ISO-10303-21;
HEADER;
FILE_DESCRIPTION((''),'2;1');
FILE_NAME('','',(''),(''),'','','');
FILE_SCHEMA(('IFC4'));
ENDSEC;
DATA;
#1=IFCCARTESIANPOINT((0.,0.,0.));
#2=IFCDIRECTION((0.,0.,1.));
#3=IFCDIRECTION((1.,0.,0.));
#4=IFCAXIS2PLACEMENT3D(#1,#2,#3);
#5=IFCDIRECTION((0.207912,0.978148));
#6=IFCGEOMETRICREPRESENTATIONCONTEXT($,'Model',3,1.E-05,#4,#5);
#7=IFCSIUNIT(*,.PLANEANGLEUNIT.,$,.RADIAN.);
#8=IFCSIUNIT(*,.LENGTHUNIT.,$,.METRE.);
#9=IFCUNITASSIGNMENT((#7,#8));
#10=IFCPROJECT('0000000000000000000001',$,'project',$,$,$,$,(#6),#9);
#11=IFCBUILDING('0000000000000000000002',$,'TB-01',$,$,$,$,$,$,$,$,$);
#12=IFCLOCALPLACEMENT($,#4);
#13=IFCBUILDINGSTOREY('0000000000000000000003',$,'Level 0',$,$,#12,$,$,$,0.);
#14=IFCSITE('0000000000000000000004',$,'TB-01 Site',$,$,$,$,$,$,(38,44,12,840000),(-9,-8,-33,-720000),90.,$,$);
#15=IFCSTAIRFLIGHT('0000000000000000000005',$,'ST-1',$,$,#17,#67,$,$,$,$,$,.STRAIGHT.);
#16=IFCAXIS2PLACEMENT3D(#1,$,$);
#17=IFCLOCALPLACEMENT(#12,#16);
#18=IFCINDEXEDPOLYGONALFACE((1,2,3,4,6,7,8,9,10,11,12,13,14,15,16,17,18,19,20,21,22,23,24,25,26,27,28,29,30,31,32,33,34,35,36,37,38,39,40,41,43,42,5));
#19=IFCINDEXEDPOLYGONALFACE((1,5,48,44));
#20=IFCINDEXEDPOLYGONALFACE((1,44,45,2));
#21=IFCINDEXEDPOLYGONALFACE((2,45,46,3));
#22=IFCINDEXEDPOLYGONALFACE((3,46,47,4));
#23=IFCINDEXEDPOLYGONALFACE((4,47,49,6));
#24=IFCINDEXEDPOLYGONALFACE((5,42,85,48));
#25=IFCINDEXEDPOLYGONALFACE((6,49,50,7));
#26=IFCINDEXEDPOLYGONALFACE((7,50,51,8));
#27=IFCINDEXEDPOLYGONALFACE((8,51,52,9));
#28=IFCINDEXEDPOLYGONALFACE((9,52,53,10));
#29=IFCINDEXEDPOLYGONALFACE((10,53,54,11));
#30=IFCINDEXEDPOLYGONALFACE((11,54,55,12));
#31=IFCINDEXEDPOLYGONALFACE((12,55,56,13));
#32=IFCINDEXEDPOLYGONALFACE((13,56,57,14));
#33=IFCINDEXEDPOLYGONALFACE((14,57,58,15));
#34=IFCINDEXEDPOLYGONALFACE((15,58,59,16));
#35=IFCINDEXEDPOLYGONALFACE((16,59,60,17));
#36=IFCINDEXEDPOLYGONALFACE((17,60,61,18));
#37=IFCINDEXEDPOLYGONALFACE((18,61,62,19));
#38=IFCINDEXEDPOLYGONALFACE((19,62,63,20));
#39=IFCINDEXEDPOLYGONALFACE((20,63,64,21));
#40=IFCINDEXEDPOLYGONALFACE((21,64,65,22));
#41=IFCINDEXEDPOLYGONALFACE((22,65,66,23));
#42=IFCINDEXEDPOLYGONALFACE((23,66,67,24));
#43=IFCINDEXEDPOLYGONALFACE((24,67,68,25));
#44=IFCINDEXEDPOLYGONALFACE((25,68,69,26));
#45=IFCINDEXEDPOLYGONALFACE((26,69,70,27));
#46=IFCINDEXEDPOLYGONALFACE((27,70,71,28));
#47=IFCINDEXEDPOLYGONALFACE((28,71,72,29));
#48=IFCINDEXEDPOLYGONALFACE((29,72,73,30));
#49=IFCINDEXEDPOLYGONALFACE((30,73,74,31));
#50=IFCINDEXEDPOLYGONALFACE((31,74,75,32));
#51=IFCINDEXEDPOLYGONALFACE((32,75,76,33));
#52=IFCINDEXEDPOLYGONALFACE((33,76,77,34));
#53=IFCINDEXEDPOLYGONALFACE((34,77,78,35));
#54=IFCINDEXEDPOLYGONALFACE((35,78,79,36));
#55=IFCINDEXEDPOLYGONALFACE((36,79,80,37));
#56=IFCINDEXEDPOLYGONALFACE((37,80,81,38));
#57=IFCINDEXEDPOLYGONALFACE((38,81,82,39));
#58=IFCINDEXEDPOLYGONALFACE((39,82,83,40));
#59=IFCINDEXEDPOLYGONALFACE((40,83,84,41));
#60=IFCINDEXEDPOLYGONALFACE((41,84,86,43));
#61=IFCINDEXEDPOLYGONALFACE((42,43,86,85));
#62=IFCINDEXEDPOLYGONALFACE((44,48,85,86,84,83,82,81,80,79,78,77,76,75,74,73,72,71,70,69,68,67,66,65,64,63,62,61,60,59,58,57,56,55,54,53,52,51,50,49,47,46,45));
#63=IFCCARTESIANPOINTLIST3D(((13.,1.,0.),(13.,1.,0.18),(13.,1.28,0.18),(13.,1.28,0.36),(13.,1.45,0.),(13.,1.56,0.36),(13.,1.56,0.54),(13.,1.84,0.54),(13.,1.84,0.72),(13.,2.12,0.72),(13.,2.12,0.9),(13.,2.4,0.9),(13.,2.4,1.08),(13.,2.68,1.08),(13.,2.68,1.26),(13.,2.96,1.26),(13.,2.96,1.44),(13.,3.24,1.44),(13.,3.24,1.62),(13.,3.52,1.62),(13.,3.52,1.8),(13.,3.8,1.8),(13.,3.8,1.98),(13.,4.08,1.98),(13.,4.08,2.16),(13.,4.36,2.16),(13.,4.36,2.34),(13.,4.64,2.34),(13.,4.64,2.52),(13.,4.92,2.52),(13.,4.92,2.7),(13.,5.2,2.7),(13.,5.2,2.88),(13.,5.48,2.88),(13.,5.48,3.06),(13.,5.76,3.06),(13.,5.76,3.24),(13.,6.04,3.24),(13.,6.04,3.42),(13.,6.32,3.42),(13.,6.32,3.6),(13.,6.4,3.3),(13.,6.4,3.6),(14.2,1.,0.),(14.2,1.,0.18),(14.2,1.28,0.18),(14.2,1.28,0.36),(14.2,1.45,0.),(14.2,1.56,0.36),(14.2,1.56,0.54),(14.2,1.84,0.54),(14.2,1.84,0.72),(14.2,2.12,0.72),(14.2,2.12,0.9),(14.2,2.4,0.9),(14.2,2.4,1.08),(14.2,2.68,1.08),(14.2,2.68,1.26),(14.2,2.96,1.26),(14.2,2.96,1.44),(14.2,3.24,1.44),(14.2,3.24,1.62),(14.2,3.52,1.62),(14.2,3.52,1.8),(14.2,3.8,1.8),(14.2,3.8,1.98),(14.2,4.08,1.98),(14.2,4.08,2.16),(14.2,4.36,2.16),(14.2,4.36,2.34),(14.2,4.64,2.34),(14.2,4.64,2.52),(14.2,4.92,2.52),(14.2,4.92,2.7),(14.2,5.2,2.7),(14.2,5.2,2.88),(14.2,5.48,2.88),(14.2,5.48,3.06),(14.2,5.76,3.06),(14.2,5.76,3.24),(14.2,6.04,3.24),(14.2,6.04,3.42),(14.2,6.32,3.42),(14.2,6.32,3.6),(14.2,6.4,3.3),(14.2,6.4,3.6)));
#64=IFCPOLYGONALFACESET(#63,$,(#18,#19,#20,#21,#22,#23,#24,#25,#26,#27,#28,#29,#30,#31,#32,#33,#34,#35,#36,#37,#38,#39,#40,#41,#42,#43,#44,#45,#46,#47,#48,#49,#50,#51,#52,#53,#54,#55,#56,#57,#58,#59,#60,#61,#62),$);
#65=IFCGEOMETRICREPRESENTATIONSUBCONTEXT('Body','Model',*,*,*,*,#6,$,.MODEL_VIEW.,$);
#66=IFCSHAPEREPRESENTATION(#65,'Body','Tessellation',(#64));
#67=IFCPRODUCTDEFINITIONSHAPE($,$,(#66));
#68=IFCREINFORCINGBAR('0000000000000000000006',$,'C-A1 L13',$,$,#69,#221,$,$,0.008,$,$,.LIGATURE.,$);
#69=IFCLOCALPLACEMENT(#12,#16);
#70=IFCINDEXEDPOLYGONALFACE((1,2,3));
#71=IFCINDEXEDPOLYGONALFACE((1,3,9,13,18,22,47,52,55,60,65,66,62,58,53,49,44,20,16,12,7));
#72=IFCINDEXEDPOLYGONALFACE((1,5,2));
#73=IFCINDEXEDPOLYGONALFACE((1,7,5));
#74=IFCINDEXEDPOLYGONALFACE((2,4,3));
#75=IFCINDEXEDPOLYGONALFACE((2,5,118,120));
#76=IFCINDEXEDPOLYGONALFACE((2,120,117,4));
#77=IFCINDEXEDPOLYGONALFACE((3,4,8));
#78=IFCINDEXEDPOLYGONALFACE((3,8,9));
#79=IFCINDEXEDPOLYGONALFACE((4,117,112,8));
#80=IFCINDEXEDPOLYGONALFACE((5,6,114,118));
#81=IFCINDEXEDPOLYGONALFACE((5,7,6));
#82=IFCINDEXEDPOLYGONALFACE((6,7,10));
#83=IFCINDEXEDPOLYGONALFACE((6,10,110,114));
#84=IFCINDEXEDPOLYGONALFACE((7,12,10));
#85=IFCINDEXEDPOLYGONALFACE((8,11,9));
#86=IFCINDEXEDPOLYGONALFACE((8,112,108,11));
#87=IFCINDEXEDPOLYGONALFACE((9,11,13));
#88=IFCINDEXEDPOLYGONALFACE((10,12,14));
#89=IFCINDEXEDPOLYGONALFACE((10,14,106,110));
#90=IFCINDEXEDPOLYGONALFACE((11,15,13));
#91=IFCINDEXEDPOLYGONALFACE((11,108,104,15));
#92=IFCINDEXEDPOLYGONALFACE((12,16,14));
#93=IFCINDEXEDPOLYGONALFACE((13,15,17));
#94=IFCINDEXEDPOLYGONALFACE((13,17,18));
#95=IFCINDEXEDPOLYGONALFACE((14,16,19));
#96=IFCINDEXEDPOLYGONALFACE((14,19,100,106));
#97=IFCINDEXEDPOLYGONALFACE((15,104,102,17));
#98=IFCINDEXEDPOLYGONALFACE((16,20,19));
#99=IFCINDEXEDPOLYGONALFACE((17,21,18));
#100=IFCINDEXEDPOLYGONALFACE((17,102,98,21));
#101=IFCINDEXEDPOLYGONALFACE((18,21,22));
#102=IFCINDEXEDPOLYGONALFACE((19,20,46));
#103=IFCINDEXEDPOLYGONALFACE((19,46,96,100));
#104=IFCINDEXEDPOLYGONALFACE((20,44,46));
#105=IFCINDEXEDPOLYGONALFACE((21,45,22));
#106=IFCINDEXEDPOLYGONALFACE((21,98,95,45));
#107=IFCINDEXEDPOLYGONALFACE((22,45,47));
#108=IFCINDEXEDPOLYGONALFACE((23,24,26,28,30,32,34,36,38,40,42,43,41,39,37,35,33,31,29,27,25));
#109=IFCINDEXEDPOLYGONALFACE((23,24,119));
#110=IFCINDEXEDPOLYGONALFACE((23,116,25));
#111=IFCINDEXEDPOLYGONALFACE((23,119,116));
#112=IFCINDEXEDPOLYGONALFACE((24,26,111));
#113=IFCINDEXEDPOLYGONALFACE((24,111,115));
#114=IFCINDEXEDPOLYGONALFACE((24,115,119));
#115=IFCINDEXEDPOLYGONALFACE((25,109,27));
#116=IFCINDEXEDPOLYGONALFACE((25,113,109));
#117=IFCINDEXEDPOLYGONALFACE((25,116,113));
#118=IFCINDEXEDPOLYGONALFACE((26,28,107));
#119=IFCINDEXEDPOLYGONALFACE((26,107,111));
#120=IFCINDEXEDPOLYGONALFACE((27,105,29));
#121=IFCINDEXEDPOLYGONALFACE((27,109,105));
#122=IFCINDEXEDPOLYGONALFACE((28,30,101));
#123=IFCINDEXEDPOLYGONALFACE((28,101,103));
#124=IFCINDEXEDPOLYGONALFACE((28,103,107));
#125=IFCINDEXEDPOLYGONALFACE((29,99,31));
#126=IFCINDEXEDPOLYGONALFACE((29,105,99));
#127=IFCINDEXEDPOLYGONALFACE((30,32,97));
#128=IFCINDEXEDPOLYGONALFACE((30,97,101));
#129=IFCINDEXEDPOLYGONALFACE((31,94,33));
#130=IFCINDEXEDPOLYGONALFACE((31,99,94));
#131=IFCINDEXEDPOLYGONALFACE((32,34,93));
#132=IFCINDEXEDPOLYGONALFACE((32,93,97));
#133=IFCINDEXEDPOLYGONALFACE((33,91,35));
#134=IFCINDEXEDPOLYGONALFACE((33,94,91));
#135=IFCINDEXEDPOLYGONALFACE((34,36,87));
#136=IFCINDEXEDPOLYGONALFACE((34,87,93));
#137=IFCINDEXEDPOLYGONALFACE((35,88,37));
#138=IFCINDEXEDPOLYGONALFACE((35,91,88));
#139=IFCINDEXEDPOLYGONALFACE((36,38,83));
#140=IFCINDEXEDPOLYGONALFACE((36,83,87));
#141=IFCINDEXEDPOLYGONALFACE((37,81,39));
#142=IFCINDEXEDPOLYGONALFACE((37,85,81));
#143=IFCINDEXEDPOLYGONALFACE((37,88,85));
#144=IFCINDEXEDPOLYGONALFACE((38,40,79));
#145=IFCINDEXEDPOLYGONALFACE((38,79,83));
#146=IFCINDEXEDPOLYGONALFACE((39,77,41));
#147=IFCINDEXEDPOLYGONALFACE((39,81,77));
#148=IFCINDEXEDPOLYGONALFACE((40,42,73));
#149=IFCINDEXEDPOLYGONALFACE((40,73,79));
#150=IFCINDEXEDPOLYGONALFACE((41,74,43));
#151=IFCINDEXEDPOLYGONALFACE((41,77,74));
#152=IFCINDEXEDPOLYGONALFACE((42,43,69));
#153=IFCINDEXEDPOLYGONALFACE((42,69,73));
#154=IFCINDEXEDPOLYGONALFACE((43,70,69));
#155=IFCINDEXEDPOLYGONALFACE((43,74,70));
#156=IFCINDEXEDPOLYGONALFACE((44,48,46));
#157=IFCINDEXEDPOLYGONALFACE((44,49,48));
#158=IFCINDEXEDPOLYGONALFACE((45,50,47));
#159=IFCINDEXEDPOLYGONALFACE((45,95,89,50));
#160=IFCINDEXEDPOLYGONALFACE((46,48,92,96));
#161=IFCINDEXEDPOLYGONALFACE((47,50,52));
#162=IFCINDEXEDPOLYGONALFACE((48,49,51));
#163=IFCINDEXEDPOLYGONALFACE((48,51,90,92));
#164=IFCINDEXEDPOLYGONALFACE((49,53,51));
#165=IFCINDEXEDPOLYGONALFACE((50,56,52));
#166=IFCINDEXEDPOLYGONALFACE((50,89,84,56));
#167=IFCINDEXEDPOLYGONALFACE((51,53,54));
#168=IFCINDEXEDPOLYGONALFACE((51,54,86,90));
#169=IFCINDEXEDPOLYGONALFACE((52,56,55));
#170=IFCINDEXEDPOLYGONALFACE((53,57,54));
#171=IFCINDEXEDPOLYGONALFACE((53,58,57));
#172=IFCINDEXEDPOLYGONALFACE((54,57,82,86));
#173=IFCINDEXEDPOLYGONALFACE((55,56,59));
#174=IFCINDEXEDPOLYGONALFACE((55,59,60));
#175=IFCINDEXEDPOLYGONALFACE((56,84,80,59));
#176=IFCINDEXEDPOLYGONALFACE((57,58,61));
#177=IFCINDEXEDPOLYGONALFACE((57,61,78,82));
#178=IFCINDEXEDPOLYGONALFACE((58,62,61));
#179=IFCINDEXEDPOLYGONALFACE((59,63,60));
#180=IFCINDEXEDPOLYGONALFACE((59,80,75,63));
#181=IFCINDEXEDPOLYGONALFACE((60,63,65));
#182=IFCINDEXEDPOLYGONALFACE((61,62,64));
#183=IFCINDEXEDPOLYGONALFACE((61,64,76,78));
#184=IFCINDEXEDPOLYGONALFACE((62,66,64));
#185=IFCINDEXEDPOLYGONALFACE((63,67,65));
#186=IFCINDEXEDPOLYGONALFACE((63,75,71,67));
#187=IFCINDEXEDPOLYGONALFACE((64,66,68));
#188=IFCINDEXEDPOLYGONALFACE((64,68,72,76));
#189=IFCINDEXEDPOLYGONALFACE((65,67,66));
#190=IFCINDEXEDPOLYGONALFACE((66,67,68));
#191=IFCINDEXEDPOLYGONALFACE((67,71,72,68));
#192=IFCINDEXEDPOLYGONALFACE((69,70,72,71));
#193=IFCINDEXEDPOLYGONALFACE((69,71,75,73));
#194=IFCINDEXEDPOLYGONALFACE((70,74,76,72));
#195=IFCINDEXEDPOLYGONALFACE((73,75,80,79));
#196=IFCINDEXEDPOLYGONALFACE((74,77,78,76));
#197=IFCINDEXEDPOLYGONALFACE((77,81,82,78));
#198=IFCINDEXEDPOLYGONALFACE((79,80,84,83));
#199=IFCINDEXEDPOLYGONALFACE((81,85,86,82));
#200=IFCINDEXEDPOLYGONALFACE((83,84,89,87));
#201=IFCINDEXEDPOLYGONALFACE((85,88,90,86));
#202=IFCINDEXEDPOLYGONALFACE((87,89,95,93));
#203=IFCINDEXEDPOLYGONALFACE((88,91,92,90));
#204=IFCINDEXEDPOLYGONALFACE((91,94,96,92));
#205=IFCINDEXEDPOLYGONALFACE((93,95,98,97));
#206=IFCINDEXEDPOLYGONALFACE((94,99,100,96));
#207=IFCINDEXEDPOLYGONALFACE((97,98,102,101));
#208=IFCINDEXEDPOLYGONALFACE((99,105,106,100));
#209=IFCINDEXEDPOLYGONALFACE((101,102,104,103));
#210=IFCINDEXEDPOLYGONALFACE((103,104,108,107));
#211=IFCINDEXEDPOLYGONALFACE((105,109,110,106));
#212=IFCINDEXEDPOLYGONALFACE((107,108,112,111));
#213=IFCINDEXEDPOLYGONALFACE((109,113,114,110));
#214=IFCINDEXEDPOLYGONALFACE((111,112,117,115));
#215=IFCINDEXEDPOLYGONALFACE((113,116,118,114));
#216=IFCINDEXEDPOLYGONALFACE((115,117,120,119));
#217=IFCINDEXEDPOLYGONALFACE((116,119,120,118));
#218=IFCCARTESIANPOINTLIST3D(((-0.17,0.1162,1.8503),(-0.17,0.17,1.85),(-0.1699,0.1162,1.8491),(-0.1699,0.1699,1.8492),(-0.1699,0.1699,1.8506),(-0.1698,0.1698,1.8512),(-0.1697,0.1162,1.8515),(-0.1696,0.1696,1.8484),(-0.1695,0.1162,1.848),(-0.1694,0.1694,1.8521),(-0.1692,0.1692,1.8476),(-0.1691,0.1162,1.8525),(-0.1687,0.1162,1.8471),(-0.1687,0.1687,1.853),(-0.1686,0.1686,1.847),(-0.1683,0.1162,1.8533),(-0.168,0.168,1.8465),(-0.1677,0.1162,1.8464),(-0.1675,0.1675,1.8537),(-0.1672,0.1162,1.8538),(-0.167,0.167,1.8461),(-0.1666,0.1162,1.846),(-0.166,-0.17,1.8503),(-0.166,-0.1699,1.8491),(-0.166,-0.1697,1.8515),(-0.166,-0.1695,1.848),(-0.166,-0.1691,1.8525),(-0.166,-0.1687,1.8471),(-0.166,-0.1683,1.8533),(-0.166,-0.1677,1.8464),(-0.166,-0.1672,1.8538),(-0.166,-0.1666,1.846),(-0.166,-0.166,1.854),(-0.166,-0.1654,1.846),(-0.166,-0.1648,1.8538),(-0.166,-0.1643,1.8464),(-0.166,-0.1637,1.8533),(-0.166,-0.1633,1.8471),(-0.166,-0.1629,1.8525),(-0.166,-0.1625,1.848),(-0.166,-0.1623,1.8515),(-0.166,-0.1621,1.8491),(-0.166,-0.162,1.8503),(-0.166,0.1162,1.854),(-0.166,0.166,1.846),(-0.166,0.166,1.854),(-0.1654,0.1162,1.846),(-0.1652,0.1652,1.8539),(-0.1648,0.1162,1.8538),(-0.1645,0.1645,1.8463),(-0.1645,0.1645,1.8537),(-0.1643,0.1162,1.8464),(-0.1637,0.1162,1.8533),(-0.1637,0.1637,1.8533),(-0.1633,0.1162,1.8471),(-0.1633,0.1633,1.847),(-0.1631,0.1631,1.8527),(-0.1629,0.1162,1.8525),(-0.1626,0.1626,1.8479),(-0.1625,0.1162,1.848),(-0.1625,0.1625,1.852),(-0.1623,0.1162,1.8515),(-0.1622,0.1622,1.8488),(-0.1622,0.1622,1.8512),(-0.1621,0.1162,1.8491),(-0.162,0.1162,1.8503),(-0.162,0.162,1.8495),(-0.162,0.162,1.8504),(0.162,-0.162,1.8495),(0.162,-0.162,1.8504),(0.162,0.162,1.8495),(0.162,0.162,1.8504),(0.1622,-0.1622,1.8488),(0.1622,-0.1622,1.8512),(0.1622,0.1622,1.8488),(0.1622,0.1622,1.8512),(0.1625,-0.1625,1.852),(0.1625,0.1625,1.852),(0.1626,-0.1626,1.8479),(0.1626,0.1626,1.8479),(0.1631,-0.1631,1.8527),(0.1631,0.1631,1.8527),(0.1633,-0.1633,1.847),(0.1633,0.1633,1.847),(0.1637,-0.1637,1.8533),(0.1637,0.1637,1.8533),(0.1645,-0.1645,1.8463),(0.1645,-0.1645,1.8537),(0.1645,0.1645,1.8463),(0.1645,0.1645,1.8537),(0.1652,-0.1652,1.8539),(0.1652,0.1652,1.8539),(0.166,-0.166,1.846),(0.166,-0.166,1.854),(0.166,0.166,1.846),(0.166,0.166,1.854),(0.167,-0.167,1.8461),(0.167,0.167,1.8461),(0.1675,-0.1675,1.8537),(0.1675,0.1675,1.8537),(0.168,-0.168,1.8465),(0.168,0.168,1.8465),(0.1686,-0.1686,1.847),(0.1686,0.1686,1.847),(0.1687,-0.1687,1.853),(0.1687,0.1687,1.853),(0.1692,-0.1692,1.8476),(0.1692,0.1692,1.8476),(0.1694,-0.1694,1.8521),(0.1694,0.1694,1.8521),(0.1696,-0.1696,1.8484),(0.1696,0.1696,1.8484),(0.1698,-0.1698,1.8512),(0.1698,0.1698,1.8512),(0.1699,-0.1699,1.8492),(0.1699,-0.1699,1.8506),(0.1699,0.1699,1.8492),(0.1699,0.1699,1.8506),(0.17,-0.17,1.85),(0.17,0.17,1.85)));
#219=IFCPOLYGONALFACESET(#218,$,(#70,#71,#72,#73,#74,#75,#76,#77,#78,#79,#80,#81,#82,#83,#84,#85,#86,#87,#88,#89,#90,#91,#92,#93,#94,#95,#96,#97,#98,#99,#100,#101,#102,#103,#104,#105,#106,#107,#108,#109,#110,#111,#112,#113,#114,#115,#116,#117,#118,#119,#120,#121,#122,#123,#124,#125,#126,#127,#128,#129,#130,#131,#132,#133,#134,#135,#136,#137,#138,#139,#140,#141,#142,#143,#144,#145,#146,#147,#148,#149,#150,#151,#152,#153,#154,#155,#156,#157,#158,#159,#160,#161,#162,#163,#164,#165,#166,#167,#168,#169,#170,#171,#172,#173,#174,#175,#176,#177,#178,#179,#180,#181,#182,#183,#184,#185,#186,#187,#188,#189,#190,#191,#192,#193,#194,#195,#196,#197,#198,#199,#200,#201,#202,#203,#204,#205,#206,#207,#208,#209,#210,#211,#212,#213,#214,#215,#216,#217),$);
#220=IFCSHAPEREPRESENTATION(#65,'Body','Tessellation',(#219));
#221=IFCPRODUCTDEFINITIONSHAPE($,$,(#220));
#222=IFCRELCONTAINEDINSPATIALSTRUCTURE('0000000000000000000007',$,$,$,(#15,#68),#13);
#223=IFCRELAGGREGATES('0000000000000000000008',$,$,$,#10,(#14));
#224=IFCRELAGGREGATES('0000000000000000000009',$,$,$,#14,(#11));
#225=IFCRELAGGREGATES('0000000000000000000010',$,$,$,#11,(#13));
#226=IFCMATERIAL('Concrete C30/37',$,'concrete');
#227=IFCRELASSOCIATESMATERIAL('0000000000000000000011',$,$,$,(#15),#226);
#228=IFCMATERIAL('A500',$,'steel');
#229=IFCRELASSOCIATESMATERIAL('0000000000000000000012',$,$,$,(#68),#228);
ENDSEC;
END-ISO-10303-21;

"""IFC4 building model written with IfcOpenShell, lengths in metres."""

from ifc_helpers import new_model, entity, si_unit, direction, frame, origin_with_axes, place, context, subcontext, project, spatial, polyline, outline, extrude, material, element, save


model = new_model("IFC4")

# Units and contexts
model_context = context("Model", 3, precision=1e-05, world=origin_with_axes(), true_north=direction((0.207912, 0.978148)))
body_context = subcontext(model_context, "Body", "Model", "MODEL_VIEW")
ifc_project = project(units=[si_unit("PLANEANGLEUNIT", "RADIAN"), si_unit("LENGTHUNIT", "METRE")], contexts=[model_context])

# Site, building, storey
site = spatial("IfcSite", under=ifc_project, Name="TB-01 Site", RefLatitude=(38, 44, 12, 840000), RefLongitude=(-9, -8, -33, -720000), RefElevation=90.0)
building = spatial("IfcBuilding", under=site, Name="TB-01")
storey_placement = place(None, origin_with_axes())
storey = spatial("IfcBuildingStorey", under=building, at=storey_placement, Name="Level 0", Elevation=0.0)

# Shared definitions
ifc_material_1 = material(Name="Concrete C30/37", Category="concrete")

# Stair flight
stair_flight_placement = place(storey_placement, frame((13.0, 1.0, 0.0), z_axis=(1.0, 0.0, 0.0), x_axis=(0.0, 1.0, 0.0)))
element("IfcStairFlight", 1, at=stair_flight_placement, inside=storey, material=ifc_material_1, Name="ST-1", PredefinedType="STRAIGHT", context=body_context, shape_type="SweptSolid", body=[
    extrude(outline(polyline([(0.0, 0.0), (0.0, 0.18), (0.28, 0.18), (0.28, 0.36), (0.56, 0.36), (0.56, 0.54), (0.84, 0.54), (0.84, 0.72), (1.12, 0.72), (1.12, 0.9), (1.4, 0.9), (1.4, 1.08), (1.68, 1.08), (1.68, 1.26), (1.96, 1.26), (1.96, 1.44), (2.24, 1.44), (2.24, 1.62), (2.52, 1.62), (2.52, 1.8), (2.8, 1.8), (2.8, 1.98), (3.08, 1.98), (3.08, 2.16), (3.36, 2.16), (3.36, 2.34), (3.64, 2.34), (3.64, 2.52), (3.92, 2.52), (3.92, 2.7), (4.2, 2.7), (4.2, 2.88), (4.48, 2.88), (4.48, 3.06), (4.76, 3.06), (4.76, 3.24), (5.04, 3.24), (5.04, 3.42), (5.32, 3.42), (5.32, 3.6), (5.4, 3.6), (5.4, 3.3), (0.45, 0.0), (0.0, 0.0)])), origin_with_axes(), (0.0, 0.0, 1.0), 1.2),
])

# Reinforcing bar
ifc_material_2 = material(Name="A500", Category="steel")
reinforcing_bar_1_placement = place(storey_placement, origin_with_axes())
element("IfcReinforcingBar", 2, at=reinforcing_bar_1_placement, inside=storey, material=ifc_material_2, Name="C-A1 L13", NominalDiameter=0.008, PredefinedType="LIGATURE", context=body_context, shape_type="AdvancedSweptSolid", body=[
    entity("IfcSweptDiskSolid", entity("IfcPolyline", [entity("IfcCartesianPoint", [-0.166, -0.166, 1.85]), entity("IfcCartesianPoint", [0.166, -0.166, 1.85]), entity("IfcCartesianPoint", [0.166, 0.166, 1.85]), entity("IfcCartesianPoint", [-0.166, 0.166, 1.85]), entity("IfcCartesianPoint", [-0.166, 0.1162, 1.85])]), 0.004),
])

save(model, "model.ifc")
